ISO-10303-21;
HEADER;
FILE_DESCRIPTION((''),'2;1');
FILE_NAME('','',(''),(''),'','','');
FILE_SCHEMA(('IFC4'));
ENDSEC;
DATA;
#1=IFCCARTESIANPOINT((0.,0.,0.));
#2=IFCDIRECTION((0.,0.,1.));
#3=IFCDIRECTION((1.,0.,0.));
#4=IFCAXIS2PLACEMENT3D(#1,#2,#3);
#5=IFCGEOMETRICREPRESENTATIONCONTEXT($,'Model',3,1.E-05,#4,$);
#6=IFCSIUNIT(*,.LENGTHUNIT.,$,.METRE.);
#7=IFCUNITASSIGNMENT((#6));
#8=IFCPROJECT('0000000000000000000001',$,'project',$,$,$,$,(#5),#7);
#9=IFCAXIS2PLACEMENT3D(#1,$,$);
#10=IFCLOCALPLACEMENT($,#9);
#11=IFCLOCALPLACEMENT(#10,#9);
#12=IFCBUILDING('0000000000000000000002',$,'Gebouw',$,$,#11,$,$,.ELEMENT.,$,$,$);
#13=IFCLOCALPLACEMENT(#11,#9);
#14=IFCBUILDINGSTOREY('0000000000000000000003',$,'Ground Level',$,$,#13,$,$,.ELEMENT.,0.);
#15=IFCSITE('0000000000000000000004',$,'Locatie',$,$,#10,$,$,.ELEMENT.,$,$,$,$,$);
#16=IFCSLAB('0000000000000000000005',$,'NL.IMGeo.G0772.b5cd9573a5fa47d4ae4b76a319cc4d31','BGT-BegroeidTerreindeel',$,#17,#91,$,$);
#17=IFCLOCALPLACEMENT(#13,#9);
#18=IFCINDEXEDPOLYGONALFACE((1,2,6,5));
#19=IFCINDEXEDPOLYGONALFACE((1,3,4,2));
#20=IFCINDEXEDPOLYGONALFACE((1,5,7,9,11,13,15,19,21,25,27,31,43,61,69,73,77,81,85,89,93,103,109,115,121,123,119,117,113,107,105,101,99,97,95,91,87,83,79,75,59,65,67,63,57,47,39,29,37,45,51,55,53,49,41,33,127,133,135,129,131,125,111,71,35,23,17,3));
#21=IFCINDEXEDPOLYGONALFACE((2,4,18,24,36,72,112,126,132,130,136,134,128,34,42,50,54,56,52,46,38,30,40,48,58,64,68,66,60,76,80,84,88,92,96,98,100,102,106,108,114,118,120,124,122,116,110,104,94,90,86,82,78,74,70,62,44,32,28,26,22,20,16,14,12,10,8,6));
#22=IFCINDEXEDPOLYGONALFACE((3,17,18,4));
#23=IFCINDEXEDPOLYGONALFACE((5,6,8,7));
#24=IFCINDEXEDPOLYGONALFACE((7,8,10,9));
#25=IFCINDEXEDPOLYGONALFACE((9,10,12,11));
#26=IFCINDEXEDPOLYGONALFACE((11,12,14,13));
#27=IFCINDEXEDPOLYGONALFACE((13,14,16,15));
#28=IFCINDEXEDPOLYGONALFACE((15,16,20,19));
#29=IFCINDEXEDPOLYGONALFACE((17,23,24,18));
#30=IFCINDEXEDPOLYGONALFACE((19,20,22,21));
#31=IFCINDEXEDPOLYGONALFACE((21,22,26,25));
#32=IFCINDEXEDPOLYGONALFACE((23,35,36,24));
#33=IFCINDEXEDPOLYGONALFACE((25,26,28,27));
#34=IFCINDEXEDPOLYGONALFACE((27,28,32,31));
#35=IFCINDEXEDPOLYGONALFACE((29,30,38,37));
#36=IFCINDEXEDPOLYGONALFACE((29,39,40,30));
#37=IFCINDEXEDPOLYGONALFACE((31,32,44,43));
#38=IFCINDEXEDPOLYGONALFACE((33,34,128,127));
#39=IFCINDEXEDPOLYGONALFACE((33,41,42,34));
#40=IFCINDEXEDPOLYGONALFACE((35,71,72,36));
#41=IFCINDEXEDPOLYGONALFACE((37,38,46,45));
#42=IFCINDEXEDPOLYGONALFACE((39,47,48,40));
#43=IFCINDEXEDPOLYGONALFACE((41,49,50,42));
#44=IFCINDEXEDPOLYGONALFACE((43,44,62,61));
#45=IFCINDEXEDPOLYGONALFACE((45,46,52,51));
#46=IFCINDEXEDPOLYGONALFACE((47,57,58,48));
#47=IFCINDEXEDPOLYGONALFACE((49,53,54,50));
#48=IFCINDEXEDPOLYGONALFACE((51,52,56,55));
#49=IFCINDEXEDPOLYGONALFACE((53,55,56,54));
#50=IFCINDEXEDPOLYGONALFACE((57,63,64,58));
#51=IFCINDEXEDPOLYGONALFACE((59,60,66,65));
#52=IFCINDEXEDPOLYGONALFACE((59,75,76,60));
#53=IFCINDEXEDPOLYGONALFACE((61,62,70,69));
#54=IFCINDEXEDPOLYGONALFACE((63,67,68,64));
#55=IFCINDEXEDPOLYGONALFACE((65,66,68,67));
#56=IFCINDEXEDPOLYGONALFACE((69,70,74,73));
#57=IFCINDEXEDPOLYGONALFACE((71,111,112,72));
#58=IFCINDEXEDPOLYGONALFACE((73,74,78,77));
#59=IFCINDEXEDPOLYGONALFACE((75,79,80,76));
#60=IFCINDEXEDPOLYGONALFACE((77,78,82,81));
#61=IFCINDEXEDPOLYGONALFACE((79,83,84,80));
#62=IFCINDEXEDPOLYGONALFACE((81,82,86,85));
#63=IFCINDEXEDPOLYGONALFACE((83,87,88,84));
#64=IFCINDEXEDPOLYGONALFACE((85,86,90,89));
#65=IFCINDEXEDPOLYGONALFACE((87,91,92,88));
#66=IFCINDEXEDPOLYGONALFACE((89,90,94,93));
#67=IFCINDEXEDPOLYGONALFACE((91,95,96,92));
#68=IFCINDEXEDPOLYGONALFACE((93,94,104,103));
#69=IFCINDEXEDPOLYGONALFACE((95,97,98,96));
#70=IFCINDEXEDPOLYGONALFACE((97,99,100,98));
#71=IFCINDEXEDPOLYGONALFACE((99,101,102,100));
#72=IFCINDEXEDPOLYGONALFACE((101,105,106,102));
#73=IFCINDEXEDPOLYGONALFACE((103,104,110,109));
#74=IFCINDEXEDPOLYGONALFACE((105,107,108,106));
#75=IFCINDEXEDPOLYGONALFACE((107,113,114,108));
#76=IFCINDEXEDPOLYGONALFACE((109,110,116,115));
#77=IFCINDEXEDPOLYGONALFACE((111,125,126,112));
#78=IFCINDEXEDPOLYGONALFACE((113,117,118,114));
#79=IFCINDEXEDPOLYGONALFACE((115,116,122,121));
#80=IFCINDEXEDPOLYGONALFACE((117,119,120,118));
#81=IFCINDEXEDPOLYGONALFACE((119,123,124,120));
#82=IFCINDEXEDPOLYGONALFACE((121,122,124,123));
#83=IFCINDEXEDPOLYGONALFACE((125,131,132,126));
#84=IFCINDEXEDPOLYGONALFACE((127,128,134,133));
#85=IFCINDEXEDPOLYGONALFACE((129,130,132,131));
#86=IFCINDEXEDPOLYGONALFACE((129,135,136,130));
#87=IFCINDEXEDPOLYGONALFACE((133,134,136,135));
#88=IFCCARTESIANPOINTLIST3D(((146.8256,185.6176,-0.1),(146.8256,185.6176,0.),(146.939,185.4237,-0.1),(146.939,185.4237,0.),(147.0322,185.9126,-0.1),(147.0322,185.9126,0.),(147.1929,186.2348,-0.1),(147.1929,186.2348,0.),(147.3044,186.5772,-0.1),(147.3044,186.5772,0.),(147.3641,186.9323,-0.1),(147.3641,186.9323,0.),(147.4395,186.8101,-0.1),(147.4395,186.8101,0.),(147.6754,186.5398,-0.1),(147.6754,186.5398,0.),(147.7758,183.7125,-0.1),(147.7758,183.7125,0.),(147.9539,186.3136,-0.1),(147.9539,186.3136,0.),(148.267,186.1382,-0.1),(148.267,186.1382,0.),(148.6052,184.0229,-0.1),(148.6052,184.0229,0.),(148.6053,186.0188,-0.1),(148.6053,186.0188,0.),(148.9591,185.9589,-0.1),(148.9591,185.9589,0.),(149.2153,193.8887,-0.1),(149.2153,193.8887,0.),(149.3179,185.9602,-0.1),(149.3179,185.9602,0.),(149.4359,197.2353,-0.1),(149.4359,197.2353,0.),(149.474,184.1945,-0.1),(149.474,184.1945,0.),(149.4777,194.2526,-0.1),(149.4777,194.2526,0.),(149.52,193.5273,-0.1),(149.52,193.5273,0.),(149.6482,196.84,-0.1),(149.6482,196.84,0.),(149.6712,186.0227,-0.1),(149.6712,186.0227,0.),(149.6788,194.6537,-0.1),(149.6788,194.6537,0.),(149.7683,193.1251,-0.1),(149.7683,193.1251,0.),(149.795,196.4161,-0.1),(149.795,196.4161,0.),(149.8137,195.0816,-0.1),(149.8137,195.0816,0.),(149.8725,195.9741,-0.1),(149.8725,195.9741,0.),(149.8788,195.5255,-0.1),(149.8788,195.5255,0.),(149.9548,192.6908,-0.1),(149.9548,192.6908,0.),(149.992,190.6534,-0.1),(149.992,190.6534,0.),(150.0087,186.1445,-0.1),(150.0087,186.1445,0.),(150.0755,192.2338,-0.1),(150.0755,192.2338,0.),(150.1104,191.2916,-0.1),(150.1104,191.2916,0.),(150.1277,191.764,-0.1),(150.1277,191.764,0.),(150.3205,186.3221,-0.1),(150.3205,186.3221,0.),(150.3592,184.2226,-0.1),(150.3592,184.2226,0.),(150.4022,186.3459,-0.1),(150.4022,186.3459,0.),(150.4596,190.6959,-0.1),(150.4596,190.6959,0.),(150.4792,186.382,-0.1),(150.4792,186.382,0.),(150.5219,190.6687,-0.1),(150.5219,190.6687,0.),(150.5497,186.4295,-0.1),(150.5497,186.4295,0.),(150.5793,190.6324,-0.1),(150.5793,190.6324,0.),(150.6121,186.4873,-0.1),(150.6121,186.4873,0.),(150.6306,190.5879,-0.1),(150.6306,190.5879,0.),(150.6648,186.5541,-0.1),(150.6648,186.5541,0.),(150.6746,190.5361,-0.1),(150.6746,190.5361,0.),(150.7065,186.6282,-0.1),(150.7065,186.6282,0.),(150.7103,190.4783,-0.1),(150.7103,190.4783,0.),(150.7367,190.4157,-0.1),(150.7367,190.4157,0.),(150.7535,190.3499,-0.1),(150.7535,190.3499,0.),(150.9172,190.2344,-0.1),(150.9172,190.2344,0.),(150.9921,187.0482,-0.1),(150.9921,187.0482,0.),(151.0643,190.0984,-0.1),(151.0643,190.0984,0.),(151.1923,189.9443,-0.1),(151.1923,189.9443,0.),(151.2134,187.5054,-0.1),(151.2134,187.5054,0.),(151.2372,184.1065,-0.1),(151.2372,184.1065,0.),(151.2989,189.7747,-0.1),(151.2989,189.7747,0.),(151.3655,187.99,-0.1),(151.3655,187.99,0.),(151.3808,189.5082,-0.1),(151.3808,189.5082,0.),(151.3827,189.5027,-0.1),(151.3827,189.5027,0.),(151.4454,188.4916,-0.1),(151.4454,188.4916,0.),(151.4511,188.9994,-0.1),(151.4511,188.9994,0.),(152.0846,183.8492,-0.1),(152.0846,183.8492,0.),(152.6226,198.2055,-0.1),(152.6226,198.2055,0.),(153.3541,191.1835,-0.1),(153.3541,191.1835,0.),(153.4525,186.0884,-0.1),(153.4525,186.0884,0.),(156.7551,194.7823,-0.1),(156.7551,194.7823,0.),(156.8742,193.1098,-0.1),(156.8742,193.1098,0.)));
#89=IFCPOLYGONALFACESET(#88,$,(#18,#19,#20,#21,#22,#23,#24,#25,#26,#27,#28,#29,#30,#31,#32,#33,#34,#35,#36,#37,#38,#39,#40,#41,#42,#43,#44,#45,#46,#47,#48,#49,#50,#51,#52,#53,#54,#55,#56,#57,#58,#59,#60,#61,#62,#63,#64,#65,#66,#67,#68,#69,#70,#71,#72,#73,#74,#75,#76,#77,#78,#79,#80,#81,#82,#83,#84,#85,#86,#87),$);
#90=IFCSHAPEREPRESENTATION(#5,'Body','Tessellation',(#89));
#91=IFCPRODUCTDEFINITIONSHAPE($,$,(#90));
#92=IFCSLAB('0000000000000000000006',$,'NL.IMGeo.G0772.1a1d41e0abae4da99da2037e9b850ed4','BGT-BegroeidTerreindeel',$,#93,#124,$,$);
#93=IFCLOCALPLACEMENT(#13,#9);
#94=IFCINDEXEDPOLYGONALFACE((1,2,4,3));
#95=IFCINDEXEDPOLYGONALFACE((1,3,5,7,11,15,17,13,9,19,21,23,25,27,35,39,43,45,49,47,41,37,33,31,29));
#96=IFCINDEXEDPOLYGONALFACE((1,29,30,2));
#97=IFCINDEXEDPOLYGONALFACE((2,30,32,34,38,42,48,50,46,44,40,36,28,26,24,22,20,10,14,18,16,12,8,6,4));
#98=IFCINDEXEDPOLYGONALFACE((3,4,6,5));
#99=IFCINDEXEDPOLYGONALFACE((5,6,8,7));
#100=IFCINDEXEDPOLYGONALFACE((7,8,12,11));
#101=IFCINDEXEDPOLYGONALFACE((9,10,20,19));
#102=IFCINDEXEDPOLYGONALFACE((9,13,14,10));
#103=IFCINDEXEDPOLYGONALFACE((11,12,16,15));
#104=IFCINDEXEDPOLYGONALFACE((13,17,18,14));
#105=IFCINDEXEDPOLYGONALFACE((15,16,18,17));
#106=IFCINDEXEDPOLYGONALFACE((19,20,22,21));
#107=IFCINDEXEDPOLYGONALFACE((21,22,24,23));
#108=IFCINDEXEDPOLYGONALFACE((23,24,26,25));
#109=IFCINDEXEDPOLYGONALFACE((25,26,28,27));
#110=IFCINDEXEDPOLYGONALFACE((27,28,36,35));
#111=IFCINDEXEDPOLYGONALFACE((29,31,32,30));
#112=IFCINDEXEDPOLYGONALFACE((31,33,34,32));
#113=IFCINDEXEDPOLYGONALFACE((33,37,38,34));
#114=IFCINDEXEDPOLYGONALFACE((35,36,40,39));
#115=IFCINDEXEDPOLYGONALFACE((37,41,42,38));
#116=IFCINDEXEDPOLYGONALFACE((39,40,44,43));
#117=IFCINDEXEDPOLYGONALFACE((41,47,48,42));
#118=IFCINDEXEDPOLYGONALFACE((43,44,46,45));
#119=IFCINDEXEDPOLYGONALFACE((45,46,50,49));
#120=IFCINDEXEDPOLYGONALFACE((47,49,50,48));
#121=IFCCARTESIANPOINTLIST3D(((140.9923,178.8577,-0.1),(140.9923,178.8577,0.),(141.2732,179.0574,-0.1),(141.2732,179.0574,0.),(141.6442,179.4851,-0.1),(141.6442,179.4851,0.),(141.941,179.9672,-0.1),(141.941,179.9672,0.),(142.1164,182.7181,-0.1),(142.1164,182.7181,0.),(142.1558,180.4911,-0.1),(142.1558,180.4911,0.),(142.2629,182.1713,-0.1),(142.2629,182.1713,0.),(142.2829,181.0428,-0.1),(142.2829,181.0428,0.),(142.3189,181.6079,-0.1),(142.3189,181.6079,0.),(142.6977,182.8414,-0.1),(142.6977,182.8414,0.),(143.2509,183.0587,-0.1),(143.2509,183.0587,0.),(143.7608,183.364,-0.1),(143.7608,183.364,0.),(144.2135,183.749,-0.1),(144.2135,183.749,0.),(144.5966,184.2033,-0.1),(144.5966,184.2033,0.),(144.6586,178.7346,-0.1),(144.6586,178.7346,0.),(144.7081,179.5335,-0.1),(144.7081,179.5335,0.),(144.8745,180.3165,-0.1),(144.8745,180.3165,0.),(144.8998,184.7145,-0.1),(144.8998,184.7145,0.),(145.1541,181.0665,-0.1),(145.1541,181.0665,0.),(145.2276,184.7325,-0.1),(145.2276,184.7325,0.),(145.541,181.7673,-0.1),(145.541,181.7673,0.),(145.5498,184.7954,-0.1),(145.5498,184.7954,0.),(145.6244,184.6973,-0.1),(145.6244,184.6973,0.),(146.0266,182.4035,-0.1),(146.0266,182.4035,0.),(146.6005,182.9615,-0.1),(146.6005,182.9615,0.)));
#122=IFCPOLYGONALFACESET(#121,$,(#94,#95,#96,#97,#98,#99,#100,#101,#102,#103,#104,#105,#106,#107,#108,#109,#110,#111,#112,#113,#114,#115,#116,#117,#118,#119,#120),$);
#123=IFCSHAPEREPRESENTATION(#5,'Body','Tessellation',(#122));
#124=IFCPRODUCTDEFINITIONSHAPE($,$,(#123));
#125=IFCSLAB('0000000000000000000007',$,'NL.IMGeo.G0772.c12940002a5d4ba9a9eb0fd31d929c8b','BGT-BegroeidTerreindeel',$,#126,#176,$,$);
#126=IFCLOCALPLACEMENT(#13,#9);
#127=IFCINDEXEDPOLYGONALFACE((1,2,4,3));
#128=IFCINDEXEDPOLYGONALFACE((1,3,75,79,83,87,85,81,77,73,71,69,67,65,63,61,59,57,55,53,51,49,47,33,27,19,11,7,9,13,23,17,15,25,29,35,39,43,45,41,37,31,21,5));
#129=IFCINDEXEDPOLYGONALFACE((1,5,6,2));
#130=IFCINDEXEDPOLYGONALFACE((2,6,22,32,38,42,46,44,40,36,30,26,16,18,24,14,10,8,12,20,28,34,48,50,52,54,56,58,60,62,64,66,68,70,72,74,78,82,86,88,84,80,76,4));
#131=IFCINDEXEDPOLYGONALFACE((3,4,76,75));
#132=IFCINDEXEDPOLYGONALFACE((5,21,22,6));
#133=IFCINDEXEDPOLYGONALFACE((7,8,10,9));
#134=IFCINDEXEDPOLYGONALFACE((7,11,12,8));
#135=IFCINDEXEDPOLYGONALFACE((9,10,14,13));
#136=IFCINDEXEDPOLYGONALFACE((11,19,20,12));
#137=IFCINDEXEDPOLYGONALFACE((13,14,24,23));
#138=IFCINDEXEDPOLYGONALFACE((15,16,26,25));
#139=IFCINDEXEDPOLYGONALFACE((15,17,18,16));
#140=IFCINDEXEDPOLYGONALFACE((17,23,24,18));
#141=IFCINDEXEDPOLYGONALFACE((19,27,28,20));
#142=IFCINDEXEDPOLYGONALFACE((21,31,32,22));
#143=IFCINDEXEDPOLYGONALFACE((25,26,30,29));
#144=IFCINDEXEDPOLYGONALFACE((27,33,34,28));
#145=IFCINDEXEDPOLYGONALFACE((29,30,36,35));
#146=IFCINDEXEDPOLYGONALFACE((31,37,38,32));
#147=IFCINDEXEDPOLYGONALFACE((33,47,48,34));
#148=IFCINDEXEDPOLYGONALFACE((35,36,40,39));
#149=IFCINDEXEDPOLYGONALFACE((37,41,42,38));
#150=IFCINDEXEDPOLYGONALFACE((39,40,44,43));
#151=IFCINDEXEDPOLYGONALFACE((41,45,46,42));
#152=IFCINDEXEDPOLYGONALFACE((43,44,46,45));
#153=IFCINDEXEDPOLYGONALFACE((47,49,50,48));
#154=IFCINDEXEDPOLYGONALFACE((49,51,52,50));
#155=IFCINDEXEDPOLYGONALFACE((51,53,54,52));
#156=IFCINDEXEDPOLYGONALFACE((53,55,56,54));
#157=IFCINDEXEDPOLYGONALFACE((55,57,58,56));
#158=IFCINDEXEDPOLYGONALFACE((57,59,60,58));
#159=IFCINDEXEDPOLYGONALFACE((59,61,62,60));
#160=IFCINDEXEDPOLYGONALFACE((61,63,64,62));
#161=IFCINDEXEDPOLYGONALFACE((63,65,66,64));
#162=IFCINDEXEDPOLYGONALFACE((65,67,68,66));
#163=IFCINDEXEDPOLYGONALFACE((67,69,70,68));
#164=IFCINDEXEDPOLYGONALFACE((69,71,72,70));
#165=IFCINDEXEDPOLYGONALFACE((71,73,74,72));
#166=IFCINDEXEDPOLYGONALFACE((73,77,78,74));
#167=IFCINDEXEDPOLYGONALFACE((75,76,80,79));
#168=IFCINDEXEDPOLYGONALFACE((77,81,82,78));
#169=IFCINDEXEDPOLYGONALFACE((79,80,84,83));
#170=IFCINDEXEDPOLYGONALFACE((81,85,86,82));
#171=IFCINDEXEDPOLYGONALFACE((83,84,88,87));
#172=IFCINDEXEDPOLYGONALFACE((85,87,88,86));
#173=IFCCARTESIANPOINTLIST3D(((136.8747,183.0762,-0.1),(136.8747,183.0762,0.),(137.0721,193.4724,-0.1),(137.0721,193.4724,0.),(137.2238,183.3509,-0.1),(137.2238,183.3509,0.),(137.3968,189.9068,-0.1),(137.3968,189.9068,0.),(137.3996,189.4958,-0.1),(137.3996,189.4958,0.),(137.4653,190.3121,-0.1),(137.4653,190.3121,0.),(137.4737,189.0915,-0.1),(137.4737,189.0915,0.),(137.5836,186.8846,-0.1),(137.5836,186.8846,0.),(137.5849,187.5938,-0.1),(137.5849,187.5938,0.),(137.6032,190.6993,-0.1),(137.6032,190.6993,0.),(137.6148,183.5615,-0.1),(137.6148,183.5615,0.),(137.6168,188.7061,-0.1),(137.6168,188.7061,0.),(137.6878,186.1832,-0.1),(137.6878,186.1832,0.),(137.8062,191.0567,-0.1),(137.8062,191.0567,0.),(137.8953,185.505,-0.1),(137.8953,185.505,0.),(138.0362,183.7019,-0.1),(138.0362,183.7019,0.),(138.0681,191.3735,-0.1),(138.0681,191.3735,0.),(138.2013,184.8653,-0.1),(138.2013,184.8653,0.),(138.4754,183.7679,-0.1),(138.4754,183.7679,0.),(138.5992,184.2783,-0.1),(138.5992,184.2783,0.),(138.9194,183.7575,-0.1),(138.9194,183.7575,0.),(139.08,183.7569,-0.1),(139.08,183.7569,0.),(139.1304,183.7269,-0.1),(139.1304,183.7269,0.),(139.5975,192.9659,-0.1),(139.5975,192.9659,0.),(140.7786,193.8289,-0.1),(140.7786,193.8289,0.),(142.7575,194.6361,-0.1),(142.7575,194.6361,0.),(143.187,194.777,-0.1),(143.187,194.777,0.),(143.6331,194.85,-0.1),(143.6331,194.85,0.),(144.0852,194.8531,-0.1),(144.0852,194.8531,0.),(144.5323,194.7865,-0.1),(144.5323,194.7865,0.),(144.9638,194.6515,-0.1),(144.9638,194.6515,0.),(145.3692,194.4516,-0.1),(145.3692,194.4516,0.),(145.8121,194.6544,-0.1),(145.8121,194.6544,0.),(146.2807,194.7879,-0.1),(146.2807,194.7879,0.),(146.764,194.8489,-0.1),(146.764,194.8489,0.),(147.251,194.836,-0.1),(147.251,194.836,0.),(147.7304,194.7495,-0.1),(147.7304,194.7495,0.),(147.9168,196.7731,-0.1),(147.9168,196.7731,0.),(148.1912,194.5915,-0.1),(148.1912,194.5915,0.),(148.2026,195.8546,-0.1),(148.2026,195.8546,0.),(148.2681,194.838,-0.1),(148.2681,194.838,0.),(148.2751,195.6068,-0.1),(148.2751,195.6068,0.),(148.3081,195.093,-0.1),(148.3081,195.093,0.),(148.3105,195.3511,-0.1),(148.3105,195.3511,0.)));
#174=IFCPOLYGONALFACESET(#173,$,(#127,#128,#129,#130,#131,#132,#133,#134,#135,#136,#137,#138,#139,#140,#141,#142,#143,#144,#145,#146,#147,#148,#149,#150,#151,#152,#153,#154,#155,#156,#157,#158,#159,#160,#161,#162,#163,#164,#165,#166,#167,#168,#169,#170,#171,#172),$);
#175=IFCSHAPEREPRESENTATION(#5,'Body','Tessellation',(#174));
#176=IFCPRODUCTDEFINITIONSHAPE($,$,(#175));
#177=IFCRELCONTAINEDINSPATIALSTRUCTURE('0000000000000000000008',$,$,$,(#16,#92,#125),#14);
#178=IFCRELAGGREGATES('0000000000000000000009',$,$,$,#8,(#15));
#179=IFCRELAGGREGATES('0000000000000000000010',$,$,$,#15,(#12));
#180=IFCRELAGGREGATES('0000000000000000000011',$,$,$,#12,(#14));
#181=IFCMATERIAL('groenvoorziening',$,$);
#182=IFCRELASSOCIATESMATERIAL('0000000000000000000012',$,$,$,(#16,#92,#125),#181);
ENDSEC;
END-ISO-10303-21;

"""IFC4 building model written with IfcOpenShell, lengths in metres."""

from ifc_helpers import new_model, si_unit, frame, origin, origin_with_axes, place, context, project, spatial, polyline, outline, extrude, material, element, save


model = new_model("IFC4")

# Units and contexts
model_context = context("Model", 3, precision=1e-05, world=origin_with_axes())
ifc_project = project(units=[si_unit("LENGTHUNIT", "METRE")], contexts=[model_context])

# Site, building, storey
site_placement = place(None, origin())
site = spatial("IfcSite", under=ifc_project, at=site_placement, Name="Locatie", CompositionType="ELEMENT")
building_placement = place(site_placement, origin())
building = spatial("IfcBuilding", under=site, at=building_placement, Name="Gebouw", CompositionType="ELEMENT")
storey_placement = place(building_placement, origin())
storey = spatial("IfcBuildingStorey", under=building, at=storey_placement, Name="Ground Level", CompositionType="ELEMENT", Elevation=0.0)

# Slabs
ifc_material = material(Name="groenvoorziening")
slab_1_placement = place(storey_placement, origin())
element("IfcSlab", 1, at=slab_1_placement, inside=storey, material=ifc_material, Name="NL.IMGeo.G0772.b5cd9573a5fa47d4ae4b76a319cc4d31", Description="BGT-BegroeidTerreindeel", context=model_context, shape_type="SweptSolid", body=[
    extrude(outline(polyline([(156.8742, 193.1098), (153.3541, 191.1835), (153.4525, 186.0884), (152.0846, 183.8492), (151.2372, 184.1065), (150.3592, 184.2226), (149.474, 184.1945), (148.6052, 184.0229), (147.7758, 183.7125), (146.939, 185.4237), (146.8256, 185.6176), (147.0322, 185.9126), (147.1929, 186.2348), (147.3044, 186.5772), (147.3641, 186.9323), (147.4395, 186.8101), (147.6754, 186.5398), (147.9539, 186.3136), (148.267, 186.1382), (148.6053, 186.0188), (148.9591, 185.9589), (149.3179, 185.9602), (149.6712, 186.0227), (150.0087, 186.1445), (150.3205, 186.3221), (150.4022, 186.3459), (150.4792, 186.382), (150.5497, 186.4295), (150.6121, 186.4873), (150.6648, 186.5541), (150.7065, 186.6282), (150.9921, 187.0482), (151.2134, 187.5054), (151.3655, 187.99), (151.4454, 188.4916), (151.4511, 188.9994), (151.3827, 189.5027), (151.3808, 189.5082), (151.2989, 189.7747), (151.1923, 189.9443), (151.0643, 190.0984), (150.9172, 190.2344), (150.7535, 190.3499), (150.7367, 190.4157), (150.7103, 190.4783), (150.6746, 190.5361), (150.6306, 190.5879), (150.5793, 190.6324), (150.5219, 190.6687), (150.4596, 190.6959), (149.992, 190.6534), (150.1104, 191.2916), (150.1277, 191.764), (150.0755, 192.2338), (149.9548, 192.6908), (149.7683, 193.1251), (149.52, 193.5273), (149.2153, 193.8887), (149.4777, 194.2526), (149.6788, 194.6537), (149.8137, 195.0816), (149.8788, 195.5255), (149.8725, 195.9741), (149.795, 196.4161), (149.6482, 196.84), (149.4359, 197.2353), (152.6226, 198.2055), (156.7551, 194.7823), (156.8742, 193.1098)])), frame((0.0, 0.0, -0.1), z_axis=(0.0, 0.0, 1.0), x_axis=(1.0, 0.0, 0.0)), (0.0, 0.0, 1.0), 0.1),
])
slab_2_placement = place(storey_placement, origin())
element("IfcSlab", 2, at=slab_2_placement, inside=storey, material=ifc_material, Name="NL.IMGeo.G0772.1a1d41e0abae4da99da2037e9b850ed4", Description="BGT-BegroeidTerreindeel", context=model_context, shape_type="SweptSolid", body=[
    extrude(outline(polyline([(146.6005, 182.9615), (146.0266, 182.4035), (145.541, 181.7673), (145.1541, 181.0665), (144.8745, 180.3165), (144.7081, 179.5335), (144.6586, 178.7346), (140.9923, 178.8577), (141.2732, 179.0574), (141.6442, 179.4851), (141.941, 179.9672), (142.1558, 180.4911), (142.2829, 181.0428), (142.3189, 181.6079), (142.2629, 182.1713), (142.1164, 182.7181), (142.6977, 182.8414), (143.2509, 183.0587), (143.7608, 183.364), (144.2135, 183.749), (144.5966, 184.2033), (144.8998, 184.7145), (145.2276, 184.7325), (145.5498, 184.7954), (145.6244, 184.6973), (146.6005, 182.9615)])), frame((0.0, 0.0, -0.1), z_axis=(0.0, 0.0, 1.0), x_axis=(1.0, 0.0, 0.0)), (0.0, 0.0, 1.0), 0.1),
])
slab_3_placement = place(storey_placement, origin())
element("IfcSlab", 3, at=slab_3_placement, inside=storey, material=ifc_material, Name="NL.IMGeo.G0772.c12940002a5d4ba9a9eb0fd31d929c8b", Description="BGT-BegroeidTerreindeel", context=model_context, shape_type="SweptSolid", body=[
    extrude(outline(polyline([(144.9638, 194.6515), (144.5323, 194.7865), (144.0852, 194.8531), (143.6331, 194.85), (143.187, 194.777), (142.7575, 194.6361), (140.7786, 193.8289), (139.5975, 192.9659), (138.0681, 191.3735), (137.8062, 191.0567), (137.6032, 190.6993), (137.4653, 190.3121), (137.3968, 189.9068), (137.3996, 189.4958), (137.4737, 189.0915), (137.6168, 188.7061), (137.5849, 187.5938), (137.5836, 186.8846), (137.6878, 186.1832), (137.8953, 185.505), (138.2013, 184.8653), (138.5992, 184.2783), (139.08, 183.7569), (139.1304, 183.7269), (138.9194, 183.7575), (138.4754, 183.7679), (138.0362, 183.7019), (137.6148, 183.5615), (137.2238, 183.3509), (136.8747, 183.0762), (137.0721, 193.4724), (147.9168, 196.7731), (148.2026, 195.8546), (148.2751, 195.6068), (148.3105, 195.3511), (148.3081, 195.093), (148.2681, 194.838), (148.1912, 194.5915), (147.7304, 194.7495), (147.251, 194.836), (146.764, 194.8489), (146.2807, 194.7879), (145.8121, 194.6544), (145.3692, 194.4516), (144.9638, 194.6515)])), frame((0.0, 0.0, -0.1), z_axis=(0.0, 0.0, 1.0), x_axis=(1.0, 0.0, 0.0)), (0.0, 0.0, 1.0), 0.1),
])

save(model, "model.ifc")
